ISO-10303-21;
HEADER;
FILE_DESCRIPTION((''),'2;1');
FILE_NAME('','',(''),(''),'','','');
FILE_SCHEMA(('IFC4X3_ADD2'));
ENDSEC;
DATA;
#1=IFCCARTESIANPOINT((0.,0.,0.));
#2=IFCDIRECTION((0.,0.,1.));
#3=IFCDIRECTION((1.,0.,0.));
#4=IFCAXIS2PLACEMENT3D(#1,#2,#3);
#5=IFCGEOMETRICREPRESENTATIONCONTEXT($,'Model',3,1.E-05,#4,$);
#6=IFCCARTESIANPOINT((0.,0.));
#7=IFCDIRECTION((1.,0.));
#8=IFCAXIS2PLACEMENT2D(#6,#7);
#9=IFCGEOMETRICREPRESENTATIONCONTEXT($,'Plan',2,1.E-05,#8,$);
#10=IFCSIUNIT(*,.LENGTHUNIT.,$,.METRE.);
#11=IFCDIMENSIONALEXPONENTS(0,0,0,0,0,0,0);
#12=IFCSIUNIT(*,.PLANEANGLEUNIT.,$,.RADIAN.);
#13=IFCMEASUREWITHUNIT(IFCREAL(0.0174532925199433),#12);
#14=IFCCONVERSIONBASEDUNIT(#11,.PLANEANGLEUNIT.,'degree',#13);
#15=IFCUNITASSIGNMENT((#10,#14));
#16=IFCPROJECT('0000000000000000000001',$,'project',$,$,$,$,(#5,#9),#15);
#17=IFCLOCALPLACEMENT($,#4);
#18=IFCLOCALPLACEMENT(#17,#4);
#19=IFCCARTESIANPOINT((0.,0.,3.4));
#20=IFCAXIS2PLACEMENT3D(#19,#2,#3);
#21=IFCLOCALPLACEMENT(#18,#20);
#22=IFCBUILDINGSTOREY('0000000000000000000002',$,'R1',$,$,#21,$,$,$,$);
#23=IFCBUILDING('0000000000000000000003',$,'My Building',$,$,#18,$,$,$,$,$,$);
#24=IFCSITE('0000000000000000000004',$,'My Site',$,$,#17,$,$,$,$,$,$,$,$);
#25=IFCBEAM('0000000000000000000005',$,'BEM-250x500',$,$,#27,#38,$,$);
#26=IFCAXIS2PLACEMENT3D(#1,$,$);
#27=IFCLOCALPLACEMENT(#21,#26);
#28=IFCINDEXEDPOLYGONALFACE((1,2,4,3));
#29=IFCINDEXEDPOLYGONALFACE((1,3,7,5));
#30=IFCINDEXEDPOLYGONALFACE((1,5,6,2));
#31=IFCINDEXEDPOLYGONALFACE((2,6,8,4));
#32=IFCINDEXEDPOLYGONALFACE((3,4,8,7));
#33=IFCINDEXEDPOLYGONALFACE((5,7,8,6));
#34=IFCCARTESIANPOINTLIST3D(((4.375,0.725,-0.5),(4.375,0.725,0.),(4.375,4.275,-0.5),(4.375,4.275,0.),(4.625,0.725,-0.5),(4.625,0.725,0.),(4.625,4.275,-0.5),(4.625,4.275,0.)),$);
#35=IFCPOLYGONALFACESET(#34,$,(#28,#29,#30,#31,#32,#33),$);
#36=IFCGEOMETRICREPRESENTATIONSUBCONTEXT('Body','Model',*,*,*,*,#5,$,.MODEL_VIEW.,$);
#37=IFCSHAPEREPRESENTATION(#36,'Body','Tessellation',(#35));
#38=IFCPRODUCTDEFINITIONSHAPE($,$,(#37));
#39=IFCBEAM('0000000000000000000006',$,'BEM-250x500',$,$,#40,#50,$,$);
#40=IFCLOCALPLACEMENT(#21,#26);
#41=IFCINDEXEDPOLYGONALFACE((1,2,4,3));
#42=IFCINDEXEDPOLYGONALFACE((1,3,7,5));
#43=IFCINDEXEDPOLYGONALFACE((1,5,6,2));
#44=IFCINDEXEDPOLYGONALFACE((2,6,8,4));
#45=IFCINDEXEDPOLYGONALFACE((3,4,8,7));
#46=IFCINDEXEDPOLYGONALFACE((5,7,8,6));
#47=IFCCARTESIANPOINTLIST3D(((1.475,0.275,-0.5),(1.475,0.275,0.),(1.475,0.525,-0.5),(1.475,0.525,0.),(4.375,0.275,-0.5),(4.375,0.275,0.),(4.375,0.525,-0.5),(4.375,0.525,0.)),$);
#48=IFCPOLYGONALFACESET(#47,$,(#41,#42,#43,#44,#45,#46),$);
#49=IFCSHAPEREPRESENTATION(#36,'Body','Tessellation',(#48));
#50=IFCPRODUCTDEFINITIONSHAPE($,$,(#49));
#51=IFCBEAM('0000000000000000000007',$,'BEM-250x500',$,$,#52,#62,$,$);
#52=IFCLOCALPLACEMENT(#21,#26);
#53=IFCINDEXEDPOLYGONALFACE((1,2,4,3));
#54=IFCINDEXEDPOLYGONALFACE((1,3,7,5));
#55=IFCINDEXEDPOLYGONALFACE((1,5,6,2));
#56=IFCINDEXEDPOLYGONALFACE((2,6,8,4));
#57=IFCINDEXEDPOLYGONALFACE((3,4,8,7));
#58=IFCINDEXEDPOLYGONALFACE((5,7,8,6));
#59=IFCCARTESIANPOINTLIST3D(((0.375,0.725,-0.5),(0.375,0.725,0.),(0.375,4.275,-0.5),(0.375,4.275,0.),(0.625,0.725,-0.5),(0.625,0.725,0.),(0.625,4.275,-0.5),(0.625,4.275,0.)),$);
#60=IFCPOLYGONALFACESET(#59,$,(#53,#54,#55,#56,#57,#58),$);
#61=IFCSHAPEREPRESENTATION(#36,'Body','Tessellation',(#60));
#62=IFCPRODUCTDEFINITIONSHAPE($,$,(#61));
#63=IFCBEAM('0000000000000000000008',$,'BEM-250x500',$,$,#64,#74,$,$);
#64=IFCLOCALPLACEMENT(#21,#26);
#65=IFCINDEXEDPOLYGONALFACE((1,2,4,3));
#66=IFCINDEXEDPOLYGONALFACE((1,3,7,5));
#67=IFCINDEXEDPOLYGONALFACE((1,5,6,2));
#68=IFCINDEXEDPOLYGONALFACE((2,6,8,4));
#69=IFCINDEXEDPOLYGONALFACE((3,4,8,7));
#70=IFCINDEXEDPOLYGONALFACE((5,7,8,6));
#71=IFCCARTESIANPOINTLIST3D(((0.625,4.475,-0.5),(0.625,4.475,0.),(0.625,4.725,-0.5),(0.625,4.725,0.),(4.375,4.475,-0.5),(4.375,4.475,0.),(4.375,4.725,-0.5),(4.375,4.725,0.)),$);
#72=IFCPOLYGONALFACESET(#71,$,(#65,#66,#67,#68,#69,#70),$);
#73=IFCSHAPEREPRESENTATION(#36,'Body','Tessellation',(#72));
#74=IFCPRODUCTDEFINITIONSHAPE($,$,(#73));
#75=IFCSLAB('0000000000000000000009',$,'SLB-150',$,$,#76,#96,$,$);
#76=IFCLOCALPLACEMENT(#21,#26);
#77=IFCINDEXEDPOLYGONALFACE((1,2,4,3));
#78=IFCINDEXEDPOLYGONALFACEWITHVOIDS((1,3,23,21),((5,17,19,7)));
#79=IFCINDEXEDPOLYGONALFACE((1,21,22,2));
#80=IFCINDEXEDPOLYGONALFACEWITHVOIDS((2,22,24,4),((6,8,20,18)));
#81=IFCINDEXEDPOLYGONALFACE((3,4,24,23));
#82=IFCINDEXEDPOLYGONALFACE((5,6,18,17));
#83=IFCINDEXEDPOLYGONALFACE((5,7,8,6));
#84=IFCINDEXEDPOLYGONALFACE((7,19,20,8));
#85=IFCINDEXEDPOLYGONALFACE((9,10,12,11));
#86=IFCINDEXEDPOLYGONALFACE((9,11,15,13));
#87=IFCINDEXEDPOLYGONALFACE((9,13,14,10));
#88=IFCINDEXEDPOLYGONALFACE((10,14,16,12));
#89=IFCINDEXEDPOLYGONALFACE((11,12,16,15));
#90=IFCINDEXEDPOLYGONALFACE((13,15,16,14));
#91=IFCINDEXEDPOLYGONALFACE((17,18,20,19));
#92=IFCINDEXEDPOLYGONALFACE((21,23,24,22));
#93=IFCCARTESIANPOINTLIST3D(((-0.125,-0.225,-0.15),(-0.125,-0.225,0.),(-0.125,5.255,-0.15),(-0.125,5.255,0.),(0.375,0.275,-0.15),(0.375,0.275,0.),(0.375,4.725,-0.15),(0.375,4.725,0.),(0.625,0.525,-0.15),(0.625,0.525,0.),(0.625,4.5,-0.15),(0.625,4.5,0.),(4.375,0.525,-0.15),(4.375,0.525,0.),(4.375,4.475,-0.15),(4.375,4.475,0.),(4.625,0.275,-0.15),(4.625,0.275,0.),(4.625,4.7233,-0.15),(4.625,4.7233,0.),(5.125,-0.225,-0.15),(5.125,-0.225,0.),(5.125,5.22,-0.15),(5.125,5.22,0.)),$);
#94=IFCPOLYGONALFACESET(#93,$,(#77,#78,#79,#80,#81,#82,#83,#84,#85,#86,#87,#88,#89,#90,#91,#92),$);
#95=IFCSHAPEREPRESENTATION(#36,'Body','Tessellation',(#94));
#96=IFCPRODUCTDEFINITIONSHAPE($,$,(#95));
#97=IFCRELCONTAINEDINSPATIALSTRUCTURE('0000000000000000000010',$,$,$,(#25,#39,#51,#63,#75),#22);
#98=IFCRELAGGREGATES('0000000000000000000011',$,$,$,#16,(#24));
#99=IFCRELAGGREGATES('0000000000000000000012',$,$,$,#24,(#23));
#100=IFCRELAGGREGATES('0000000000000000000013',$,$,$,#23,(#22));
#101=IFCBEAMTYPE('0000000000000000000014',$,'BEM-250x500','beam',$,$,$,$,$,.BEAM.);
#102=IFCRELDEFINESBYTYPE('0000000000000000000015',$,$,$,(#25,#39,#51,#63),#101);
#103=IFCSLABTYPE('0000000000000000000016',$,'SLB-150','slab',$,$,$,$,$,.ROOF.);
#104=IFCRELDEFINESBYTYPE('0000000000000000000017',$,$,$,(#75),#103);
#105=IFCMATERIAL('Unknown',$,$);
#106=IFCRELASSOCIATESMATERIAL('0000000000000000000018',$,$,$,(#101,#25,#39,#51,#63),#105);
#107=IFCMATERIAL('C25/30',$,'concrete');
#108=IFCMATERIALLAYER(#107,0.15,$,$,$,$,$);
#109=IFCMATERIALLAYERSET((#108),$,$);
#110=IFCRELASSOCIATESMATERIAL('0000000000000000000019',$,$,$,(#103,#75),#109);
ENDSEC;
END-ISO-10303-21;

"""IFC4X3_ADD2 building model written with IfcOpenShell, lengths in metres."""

from ifc_helpers import new_model, entity, si_unit, converted_unit, frame, origin_with_axes, origin_2d_with_axis, place, context, subcontext, project, spatial, indexed_curve, rectangle, outline, composite_profile, extrude, material, layer, layer_set, layer_usage, material_profile, profile_set, profile_usage, type_object, element, save


model = new_model("IFC4X3_ADD2")

# Units and contexts
model_context = context("Model", 3, precision=1e-05, world=origin_with_axes())
plan_context = context("Plan", 2, precision=1e-05, world=origin_2d_with_axis())
body_context = subcontext(model_context, "Body", "Model", "MODEL_VIEW")
ifc_project = project(units=[si_unit("LENGTHUNIT", "METRE"), converted_unit("PLANEANGLEUNIT", "degree", entity("IfcReal", 0.0174532925199433), si_unit("PLANEANGLEUNIT", "RADIAN"), dimensions=[0, 0, 0, 0, 0, 0, 0])], contexts=[model_context, plan_context])

# Site, building, storey
site_placement = place(None, origin_with_axes())
site = spatial("IfcSite", under=ifc_project, at=site_placement, Name="My Site")
building_placement = place(site_placement, origin_with_axes())
building = spatial("IfcBuilding", under=site, at=building_placement, Name="My Building")
storey_placement = place(building_placement, frame((0.0, 0.0, 3.4), z_axis=(0.0, 0.0, 1.0), x_axis=(1.0, 0.0, 0.0)))
storey = spatial("IfcBuildingStorey", under=building, at=storey_placement, Name="R1")

# Beams
ifc_material_1 = material(Name="Unknown")
ifc_material_profile = material_profile(ifc_material_1, rectangle(XDim=0.25, YDim=0.5))
ifc_profile_set = profile_set([ifc_material_profile])
ifc_profile_usage_1 = profile_usage(ifc_profile_set, cardinal=8)
beam_type = type_object("IfcBeamType", Name="BEM-250x500", Description="beam", PredefinedType="BEAM", material=ifc_profile_set)
beam_1_placement = place(storey_placement, frame((4.5, 0.725, 0.0), z_axis=(0.0, 1.0, 0.0), x_axis=(-1.0, 0.0, 0.0)))
element("IfcBeam", 1, at=beam_1_placement, inside=storey, type_object=beam_type, material=ifc_profile_usage_1, Name="BEM-250x500", context=body_context, shape_type="SweptSolid", body=[
    extrude(rectangle(XDim=0.25, YDim=0.5), frame((0.0, -0.25, 0.0), z_axis=(0.0, 0.0, 1.0), x_axis=(1.0, 0.0, 0.0)), (0.0, 0.0, 1.0), 3.55),
])
ifc_profile_usage_2 = profile_usage(ifc_profile_set, cardinal=8)
beam_2_placement = place(storey_placement, frame((4.375, 0.4, 0.0), z_axis=(-1.0, 0.0, 0.0), x_axis=(0.0, -1.0, 0.0)))
element("IfcBeam", 2, at=beam_2_placement, inside=storey, type_object=beam_type, material=ifc_profile_usage_2, Name="BEM-250x500", context=body_context, shape_type="SweptSolid", body=[
    extrude(rectangle(XDim=0.25, YDim=0.5), frame((0.0, -0.25, 0.0), z_axis=(0.0, 0.0, 1.0), x_axis=(1.0, 0.0, 0.0)), (0.0, 0.0, 1.0), 2.9),
])
ifc_profile_usage_3 = profile_usage(ifc_profile_set, cardinal=8)
beam_3_placement = place(storey_placement, frame((0.5, 0.725, 0.0), z_axis=(0.0, 1.0, 0.0), x_axis=(-1.0, 0.0, 0.0)))
element("IfcBeam", 3, at=beam_3_placement, inside=storey, type_object=beam_type, material=ifc_profile_usage_3, Name="BEM-250x500", context=body_context, shape_type="SweptSolid", body=[
    extrude(rectangle(XDim=0.25, YDim=0.5), frame((0.0, -0.25, 0.0), z_axis=(0.0, 0.0, 1.0), x_axis=(1.0, 0.0, 0.0)), (0.0, 0.0, 1.0), 3.55),
])
ifc_profile_usage_4 = profile_usage(ifc_profile_set, cardinal=8)
beam_4_placement = place(storey_placement, frame((4.375, 4.6, 0.0), z_axis=(-1.0, 0.0, 0.0), x_axis=(0.0, -1.0, 0.0)))
element("IfcBeam", 4, at=beam_4_placement, inside=storey, type_object=beam_type, material=ifc_profile_usage_4, Name="BEM-250x500", context=body_context, shape_type="SweptSolid", body=[
    extrude(rectangle(XDim=0.25, YDim=0.5), frame((0.0, -0.25, 0.0), z_axis=(0.0, 0.0, 1.0), x_axis=(1.0, 0.0, 0.0)), (0.0, 0.0, 1.0), 3.75),
])

# Slab
ifc_material_2 = material(Name="C25/30", Category="concrete")
ifc_layer = layer(ifc_material_2, 0.15)
ifc_layer_set = layer_set([ifc_layer])
ifc_layer_usage = layer_usage(ifc_layer_set, "AXIS3", "POSITIVE", -0.15)
slab_type = type_object("IfcSlabType", Name="SLB-150", Description="slab", PredefinedType="ROOF", material=ifc_layer_set)
slab_placement = place(storey_placement, frame((0.625, 4.5, 0.0), z_axis=(0.0, 0.0, 1.0), x_axis=(1.0, 0.0, 0.0)))
element("IfcSlab", 5, at=slab_placement, inside=storey, type_object=slab_type, material=ifc_layer_usage, Name="SLB-150", context=body_context, shape_type="SweptSolid", body=[
    extrude(composite_profile([outline(indexed_curve([(-0.75, 0.755), (4.5, 0.72), (4.5, -4.725), (-0.75, -4.725), (-0.75, 0.755)]), holes=[indexed_curve([(-0.25, 0.225), (4.0, 0.2233), (4.0, -4.225), (-0.25, -4.225), (-0.25, 0.225)])]), outline(indexed_curve([(0.0, 0.0), (3.75, -0.025), (3.75, -3.975), (0.0, -3.975), (0.0, 0.0)]))]), frame((0.0, 0.0, -0.15), z_axis=(0.0, 0.0, 1.0), x_axis=(1.0, 0.0, 0.0)), (0.0, 0.0, 1.0), 0.15),
])

save(model, "model.ifc")
